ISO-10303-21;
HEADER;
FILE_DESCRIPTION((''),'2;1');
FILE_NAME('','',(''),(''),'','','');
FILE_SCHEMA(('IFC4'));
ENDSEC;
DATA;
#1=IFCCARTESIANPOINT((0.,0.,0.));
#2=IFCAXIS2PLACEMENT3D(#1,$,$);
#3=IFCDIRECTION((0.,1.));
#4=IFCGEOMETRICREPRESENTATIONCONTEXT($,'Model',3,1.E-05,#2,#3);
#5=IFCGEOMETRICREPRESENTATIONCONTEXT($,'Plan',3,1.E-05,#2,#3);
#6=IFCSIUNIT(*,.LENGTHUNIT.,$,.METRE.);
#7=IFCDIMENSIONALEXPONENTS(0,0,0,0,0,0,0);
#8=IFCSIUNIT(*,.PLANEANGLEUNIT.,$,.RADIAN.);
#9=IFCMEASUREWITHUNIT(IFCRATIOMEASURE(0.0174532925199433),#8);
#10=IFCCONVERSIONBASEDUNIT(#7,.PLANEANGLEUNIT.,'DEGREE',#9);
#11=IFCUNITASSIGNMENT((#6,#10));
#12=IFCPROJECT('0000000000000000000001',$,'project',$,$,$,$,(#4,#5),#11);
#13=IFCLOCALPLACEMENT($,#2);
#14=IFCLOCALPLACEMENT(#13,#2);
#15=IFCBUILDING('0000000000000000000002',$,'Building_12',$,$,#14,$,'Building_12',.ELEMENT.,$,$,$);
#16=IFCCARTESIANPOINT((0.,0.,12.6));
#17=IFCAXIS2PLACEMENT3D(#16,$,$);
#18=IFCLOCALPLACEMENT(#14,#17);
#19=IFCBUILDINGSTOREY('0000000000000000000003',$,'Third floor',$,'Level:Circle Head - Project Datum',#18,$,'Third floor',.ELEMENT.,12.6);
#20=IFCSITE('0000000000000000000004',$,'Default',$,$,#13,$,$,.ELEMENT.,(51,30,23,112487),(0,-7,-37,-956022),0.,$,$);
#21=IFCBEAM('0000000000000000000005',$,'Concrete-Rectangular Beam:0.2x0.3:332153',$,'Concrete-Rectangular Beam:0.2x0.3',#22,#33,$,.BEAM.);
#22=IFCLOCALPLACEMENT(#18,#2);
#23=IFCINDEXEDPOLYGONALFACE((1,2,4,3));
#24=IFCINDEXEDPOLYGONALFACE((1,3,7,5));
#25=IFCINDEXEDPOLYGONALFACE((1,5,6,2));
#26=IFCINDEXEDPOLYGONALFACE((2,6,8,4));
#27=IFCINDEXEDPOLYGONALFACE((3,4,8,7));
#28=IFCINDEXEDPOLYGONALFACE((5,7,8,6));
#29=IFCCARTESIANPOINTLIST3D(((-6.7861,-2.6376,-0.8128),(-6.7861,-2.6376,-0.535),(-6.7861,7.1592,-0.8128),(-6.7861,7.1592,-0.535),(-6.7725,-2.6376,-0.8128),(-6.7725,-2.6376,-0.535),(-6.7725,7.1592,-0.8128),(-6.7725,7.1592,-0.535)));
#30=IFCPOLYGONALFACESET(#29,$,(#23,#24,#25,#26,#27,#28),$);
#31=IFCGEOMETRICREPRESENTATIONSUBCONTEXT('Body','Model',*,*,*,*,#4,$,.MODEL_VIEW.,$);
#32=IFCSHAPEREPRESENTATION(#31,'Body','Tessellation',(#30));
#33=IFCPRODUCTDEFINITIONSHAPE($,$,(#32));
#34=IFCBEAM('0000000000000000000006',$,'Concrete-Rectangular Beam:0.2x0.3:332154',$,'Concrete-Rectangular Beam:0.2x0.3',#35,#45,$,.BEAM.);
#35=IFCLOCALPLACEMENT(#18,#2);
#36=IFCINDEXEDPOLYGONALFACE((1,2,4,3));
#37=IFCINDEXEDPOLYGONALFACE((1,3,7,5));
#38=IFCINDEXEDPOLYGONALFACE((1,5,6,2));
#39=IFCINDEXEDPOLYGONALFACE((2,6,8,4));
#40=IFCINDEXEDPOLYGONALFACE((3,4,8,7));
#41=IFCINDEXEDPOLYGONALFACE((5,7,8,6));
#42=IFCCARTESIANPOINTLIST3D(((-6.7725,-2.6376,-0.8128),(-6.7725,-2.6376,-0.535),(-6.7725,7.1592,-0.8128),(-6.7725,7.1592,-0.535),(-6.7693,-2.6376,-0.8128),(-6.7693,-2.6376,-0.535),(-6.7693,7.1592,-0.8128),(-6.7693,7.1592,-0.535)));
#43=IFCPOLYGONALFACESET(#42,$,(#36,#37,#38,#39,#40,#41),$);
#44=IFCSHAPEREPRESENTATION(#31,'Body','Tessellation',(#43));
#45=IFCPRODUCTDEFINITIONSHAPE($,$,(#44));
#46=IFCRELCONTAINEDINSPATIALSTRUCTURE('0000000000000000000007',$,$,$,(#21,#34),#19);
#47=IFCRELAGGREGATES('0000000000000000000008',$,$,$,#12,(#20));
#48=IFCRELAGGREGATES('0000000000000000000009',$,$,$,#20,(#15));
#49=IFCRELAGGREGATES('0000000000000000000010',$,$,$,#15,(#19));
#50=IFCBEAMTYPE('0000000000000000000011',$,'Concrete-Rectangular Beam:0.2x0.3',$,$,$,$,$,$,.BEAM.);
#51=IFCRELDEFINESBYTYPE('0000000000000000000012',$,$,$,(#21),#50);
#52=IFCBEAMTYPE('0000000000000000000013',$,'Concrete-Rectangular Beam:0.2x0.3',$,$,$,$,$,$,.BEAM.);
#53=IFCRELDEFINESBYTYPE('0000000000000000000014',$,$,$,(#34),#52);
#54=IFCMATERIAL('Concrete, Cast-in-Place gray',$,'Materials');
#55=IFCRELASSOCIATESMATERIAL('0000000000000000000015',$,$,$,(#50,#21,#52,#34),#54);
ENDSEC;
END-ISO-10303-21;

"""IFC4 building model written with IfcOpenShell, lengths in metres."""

from ifc_helpers import new_model, entity, si_unit, converted_unit, direction, frame, origin, place, context, subcontext, project, spatial, indexed_curve, outline, extrude, source, transform, mapped, material, type_object, type_shapes, element, save


model = new_model("IFC4")

# Units and contexts
model_context = context("Model", 3, precision=1e-05, world=origin(), true_north=direction((0.0, 1.0)))
plan_context = context("Plan", 3, precision=1e-05, world=origin(), true_north=direction((0.0, 1.0)))
body_context = subcontext(model_context, "Body", "Model", "MODEL_VIEW")
ifc_project = project(units=[si_unit("LENGTHUNIT", "METRE"), converted_unit("PLANEANGLEUNIT", "DEGREE", entity("IfcRatioMeasure", 0.0174532925199433), si_unit("PLANEANGLEUNIT", "RADIAN"), dimensions=[0, 0, 0, 0, 0, 0, 0])], contexts=[model_context, plan_context])

# Site, building, storey
site_placement = place(None, origin())
site = spatial("IfcSite", under=ifc_project, at=site_placement, Name="Default", CompositionType="ELEMENT", RefLatitude=(51, 30, 23, 112487), RefLongitude=(0, -7, -37, -956022), RefElevation=0.0)
building_placement = place(site_placement, origin())
building = spatial("IfcBuilding", under=site, at=building_placement, Name="Building_12", LongName="Building_12", CompositionType="ELEMENT")
storey_placement = place(building_placement, frame((0.0, 0.0, 12.6)))
storey = spatial("IfcBuildingStorey", under=building, at=storey_placement, Name="Third floor", ObjectType="Level:Circle Head - Project Datum", LongName="Third floor", CompositionType="ELEMENT", Elevation=12.6)

# Beams
ifc_material_1 = material(Name="Concrete, Cast-in-Place gray", Category="Materials")
beam_type_1 = type_object("IfcBeamType", Name="Concrete-Rectangular Beam:0.2x0.3", PredefinedType="BEAM", material=ifc_material_1)
shared_shape_1 = source(origin(), body_context, "Body", "SweptSolid", [
    extrude(outline(indexed_curve([(-0.0068, -0.1389), (0.0068, -0.1389), (0.0068, 0.1389), (-0.0068, 0.1389), (-0.0068, -0.1389)], self_intersect=False)), frame((-6.7793, 7.1592, 11.9261), z_axis=(0.0, -1.0, 0.0), x_axis=(-1.0, 0.0, 0.0)), (0.0, 0.0, 1.0), 9.7968),
])
type_shapes(beam_type_1, [shared_shape_1])
beam_1_placement = place(storey_placement, frame((0.0, 0.0, -12.6)))
element("IfcBeam", 1, at=beam_1_placement, inside=storey, type_object=beam_type_1, material=ifc_material_1, Name="Concrete-Rectangular Beam:0.2x0.3:332153", ObjectType="Concrete-Rectangular Beam:0.2x0.3", PredefinedType="BEAM", context=body_context, shape_type="MappedRepresentation", body=[
    mapped(shared_shape_1, transform((0.0, 0.0, 0.0), scale=1.0)),
])
beam_type_2 = type_object("IfcBeamType", Name="Concrete-Rectangular Beam:0.2x0.3", PredefinedType="BEAM", material=ifc_material_1)
shared_shape_2 = source(origin(), body_context, "Body", "SweptSolid", [
    extrude(outline(indexed_curve([(-0.0016, -0.1389), (0.0016, -0.1389), (0.0016, 0.1389), (-0.0016, 0.1389), (-0.0016, -0.1389)], self_intersect=False)), frame((-6.7709, 7.1592, 11.9261), z_axis=(0.0, -1.0, 0.0), x_axis=(-1.0, 0.0, 0.0)), (0.0, 0.0, 1.0), 9.7968),
])
type_shapes(beam_type_2, [shared_shape_2])
beam_2_placement = place(storey_placement, frame((0.0, 0.0, -12.6)))
element("IfcBeam", 2, at=beam_2_placement, inside=storey, type_object=beam_type_2, material=ifc_material_1, Name="Concrete-Rectangular Beam:0.2x0.3:332154", ObjectType="Concrete-Rectangular Beam:0.2x0.3", PredefinedType="BEAM", context=body_context, shape_type="MappedRepresentation", body=[
    mapped(shared_shape_2, transform((0.0, 0.0, 0.0), scale=1.0)),
])

save(model, "model.ifc")
